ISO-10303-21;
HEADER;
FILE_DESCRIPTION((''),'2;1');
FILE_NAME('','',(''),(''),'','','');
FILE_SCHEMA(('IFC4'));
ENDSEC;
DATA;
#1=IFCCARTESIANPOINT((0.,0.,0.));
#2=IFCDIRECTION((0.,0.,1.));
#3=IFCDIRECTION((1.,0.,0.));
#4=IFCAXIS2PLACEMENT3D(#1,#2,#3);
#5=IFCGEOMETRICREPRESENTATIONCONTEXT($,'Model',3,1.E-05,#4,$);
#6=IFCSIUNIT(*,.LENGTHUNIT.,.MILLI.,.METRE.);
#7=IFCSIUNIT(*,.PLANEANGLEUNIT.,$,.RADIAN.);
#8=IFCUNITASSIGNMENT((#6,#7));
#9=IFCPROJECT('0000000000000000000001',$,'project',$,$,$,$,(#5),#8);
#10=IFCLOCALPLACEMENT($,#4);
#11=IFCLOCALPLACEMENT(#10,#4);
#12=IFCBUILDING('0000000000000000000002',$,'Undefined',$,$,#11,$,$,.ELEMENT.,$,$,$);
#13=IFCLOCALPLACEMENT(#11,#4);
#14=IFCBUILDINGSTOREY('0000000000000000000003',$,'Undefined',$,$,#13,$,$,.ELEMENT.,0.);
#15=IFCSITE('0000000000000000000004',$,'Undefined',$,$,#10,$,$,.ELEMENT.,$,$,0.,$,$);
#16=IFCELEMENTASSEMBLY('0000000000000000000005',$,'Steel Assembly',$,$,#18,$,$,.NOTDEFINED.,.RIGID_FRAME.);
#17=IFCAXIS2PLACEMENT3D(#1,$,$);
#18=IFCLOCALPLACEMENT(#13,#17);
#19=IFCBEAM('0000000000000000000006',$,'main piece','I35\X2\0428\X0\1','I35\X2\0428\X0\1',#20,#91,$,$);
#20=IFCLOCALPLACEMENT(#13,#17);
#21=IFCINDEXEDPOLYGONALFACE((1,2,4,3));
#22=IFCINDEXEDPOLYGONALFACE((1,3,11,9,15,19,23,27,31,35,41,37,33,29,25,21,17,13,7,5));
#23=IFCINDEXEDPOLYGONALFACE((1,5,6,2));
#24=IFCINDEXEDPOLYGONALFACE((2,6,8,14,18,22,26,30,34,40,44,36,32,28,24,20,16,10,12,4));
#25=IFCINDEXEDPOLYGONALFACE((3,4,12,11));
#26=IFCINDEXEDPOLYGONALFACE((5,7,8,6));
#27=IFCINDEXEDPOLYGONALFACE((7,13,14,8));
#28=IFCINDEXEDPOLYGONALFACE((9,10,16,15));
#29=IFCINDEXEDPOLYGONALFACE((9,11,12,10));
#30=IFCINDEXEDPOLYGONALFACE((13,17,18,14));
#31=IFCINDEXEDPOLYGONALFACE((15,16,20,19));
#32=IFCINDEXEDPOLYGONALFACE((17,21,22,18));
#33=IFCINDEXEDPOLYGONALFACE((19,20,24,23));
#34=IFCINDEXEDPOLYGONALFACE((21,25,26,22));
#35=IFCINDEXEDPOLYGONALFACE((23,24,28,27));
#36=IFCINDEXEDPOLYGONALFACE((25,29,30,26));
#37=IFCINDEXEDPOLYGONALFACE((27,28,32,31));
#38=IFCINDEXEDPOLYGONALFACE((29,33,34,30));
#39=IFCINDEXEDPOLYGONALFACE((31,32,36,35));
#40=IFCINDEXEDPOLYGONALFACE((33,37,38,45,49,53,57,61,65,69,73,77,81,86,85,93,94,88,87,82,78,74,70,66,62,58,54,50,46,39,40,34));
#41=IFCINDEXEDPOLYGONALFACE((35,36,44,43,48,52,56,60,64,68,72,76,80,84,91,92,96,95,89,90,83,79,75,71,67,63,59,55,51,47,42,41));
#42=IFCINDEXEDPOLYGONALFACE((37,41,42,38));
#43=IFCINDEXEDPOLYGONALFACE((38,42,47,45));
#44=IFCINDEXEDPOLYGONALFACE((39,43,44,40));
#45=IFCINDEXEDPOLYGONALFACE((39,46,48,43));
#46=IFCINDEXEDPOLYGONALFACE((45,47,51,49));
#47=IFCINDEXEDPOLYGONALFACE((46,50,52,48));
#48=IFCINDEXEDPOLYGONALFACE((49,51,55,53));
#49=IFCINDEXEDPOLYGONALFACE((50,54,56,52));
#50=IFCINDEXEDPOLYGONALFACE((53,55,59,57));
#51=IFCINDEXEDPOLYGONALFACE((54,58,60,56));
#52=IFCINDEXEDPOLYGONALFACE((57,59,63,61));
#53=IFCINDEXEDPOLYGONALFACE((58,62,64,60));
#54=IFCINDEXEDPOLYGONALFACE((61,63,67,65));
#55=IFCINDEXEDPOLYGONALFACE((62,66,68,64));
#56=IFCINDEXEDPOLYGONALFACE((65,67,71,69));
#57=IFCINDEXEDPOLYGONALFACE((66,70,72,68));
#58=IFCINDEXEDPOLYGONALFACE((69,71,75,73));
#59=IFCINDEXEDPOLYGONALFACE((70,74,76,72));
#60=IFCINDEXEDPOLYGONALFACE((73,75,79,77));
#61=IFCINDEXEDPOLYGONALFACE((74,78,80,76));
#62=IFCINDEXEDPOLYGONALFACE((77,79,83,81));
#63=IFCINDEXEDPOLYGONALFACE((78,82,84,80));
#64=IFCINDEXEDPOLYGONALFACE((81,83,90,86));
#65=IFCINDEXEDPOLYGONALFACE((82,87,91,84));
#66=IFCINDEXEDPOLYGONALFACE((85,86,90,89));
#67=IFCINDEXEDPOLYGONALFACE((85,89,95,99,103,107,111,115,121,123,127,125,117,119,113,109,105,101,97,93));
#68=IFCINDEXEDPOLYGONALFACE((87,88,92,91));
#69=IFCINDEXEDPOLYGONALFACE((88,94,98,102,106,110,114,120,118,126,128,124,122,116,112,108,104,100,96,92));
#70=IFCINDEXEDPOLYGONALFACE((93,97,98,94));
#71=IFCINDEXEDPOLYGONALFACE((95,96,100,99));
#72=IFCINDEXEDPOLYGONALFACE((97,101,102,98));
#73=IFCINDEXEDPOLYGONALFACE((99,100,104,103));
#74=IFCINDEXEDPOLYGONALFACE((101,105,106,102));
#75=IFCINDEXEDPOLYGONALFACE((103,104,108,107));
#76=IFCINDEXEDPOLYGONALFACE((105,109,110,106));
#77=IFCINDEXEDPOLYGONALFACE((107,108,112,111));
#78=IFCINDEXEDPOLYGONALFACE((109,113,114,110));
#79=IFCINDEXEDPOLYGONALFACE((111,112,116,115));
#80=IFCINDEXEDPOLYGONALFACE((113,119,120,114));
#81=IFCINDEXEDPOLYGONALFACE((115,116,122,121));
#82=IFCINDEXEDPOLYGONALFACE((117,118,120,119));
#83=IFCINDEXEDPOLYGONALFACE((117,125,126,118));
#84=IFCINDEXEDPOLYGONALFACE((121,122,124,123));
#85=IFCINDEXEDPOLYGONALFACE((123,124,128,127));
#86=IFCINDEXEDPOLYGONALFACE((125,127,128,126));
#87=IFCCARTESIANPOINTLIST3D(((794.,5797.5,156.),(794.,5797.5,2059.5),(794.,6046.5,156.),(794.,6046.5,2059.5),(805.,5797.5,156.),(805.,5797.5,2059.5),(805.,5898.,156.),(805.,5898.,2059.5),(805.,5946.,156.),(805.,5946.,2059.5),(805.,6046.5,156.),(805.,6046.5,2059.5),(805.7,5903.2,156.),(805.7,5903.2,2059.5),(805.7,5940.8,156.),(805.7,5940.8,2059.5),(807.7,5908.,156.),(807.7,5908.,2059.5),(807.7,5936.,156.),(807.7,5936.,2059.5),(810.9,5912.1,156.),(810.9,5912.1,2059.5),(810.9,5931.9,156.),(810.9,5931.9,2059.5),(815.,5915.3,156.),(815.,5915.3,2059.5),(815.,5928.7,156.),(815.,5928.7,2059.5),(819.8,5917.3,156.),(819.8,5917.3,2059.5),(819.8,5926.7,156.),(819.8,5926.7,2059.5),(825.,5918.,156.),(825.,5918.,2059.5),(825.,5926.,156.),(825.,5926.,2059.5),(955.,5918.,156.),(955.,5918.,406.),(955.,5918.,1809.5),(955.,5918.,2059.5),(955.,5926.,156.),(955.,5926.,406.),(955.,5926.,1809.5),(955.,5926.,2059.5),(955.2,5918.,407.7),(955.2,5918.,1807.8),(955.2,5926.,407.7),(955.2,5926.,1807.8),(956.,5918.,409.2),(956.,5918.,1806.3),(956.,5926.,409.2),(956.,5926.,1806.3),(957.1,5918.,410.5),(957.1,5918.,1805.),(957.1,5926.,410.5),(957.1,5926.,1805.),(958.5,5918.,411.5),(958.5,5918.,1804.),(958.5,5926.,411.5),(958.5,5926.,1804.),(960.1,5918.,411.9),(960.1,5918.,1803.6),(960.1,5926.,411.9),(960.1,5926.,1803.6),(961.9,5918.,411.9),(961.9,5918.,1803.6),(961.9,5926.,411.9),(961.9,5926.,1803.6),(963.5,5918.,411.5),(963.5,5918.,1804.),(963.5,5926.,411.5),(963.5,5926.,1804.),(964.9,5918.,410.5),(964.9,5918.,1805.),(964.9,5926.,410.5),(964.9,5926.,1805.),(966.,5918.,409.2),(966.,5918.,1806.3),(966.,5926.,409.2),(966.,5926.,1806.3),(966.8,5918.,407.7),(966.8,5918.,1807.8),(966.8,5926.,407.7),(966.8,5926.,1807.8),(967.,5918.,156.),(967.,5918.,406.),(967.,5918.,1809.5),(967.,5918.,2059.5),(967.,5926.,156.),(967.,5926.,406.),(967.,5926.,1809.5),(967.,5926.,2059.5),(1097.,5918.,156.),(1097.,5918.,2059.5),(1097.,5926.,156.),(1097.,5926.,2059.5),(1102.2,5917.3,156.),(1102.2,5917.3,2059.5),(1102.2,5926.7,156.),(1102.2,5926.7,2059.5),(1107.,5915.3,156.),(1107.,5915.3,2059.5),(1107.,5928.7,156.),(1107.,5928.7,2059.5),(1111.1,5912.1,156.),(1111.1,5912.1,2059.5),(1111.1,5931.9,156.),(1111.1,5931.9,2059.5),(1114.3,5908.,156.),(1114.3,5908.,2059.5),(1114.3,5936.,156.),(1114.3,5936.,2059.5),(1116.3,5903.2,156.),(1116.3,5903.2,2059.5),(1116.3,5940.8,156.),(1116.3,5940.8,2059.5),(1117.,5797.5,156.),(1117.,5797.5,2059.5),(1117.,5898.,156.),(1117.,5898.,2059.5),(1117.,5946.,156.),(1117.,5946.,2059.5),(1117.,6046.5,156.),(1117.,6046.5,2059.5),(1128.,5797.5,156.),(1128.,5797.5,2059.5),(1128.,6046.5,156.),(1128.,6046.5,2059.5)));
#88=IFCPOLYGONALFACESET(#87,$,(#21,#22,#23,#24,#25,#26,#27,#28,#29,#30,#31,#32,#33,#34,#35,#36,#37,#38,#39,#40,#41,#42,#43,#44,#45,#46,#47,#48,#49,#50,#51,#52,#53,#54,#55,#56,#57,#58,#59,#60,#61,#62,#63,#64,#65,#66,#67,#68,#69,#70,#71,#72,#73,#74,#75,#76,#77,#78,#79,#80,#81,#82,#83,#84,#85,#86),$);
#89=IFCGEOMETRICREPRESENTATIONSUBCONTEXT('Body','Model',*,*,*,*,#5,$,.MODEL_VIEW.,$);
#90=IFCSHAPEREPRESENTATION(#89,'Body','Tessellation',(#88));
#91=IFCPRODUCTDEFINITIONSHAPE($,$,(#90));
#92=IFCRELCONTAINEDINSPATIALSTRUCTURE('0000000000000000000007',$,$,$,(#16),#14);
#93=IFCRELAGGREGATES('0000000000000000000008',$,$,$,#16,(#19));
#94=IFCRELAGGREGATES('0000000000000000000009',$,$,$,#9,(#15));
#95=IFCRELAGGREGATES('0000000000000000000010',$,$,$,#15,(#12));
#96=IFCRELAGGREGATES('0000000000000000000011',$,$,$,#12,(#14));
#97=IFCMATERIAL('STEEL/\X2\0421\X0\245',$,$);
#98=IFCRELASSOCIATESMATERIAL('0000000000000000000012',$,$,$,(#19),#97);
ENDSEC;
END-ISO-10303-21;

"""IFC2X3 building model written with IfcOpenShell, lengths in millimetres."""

from ifc_helpers import new_model, si_unit, frame, frame_2d, origin_with_axes, origin_2d_with_axis, place, context, subcontext, project, spatial, polyline, circle_curve, parameter, trimmed, segment, composite_curve, i_section, outline, extrude, clip, halfspace, material, element, aggregate, save


model = new_model("IFC2X3")

# Units and contexts
model_context = context("Model", 3, precision=1e-05, world=origin_with_axes())
body_context = subcontext(model_context, "Body", "Model", "MODEL_VIEW")
ifc_project = project(units=[si_unit("LENGTHUNIT", "METRE", prefix="MILLI"), si_unit("PLANEANGLEUNIT", "RADIAN")], contexts=[model_context])

# Site, building, storey
site_placement = place(None, origin_with_axes())
site = spatial("IfcSite", under=ifc_project, at=site_placement, Name="Undefined", CompositionType="ELEMENT", RefElevation=0.0)
building_placement = place(site_placement, origin_with_axes())
building = spatial("IfcBuilding", under=site, at=building_placement, Name="Undefined", CompositionType="ELEMENT")
storey_placement = place(building_placement, origin_with_axes())
storey = spatial("IfcBuildingStorey", under=building, at=storey_placement, Name="Undefined", CompositionType="ELEMENT", Elevation=0.0)

# Element assembly, beam, openings
assembly_1_placement = place(storey_placement, origin_with_axes())
assembly_1 = element("IfcElementAssembly", 1, at=assembly_1_placement, inside=storey, Name="Steel Assembly", AssemblyPlace="NOTDEFINED", PredefinedType="RIGID_FRAME")
ifc_material_1 = material(Name="STEEL/С245")
beam_placement = place(assembly_1_placement, frame((961.0, 5922.0, 2059.5), z_axis=(1.0, 0.0, 0.0), x_axis=(0.0, 0.0, -1.0)))
beam = element("IfcBeam", 2, at=beam_placement, material=ifc_material_1, Name="main piece", Description="I35Ш1", ObjectType="I35Ш1", context=body_context, shape_type="Clipping", body=[
    clip(clip(extrude(i_section(OverallWidth=249.0, OverallDepth=334.0, WebThickness=8.0, FlangeThickness=11.0, FilletRadius=20.0, at=origin_2d_with_axis()), frame((1903.5, 0.0, 0.0), z_axis=(-1.0, 0.0, 0.0), x_axis=(0.0, -1.0, 0.0)), (0.0, 0.0, 1.0), 1903.5), halfspace(frame((1903.5, 0.6, 274.0), z_axis=(-1.0, 0.0, 0.0), x_axis=(0.0, -1.0, 0.0)), True)), halfspace(frame((0.0, -0.6, 274.0), z_axis=(1.0, 0.0, 0.0), x_axis=(0.0, 1.0, 0.0)), True)),
])
opening_1_placement = place(assembly_1_placement, frame((961.0, 5922.0, 2059.5), z_axis=(1.0, 0.0, 0.0), x_axis=(0.0, 0.0, -1.0)))
element("IfcOpeningElement", 3, at=opening_1_placement, cuts=beam, ObjectType="Recess", context=body_context, shape_type="SweptSolid", body=[
    extrude(outline(composite_curve([segment(polyline([(0.0, 0.0), (250.0, 0.0)]), True, "CONTINUOUS"), segment(trimmed(circle_curve(frame_2d((250.0, 6.0), x_axis=(-0.000939, -1.0)), 6.0), [parameter(0.0)], [parameter(3.14347)], True, "PARAMETER"), True, "CONTINUOUS"), segment(polyline([(250.0, 12.0), (0.0, 12.0), (0.0, 0.0)]), True, "DISCONTINUOUS")], self_intersect=False)), frame((1903.5, -102.5, -6.0), z_axis=(0.0, 1.0, 0.0), x_axis=(-1.0, 0.0, 0.0)), (0.0, 0.0, 1.0), 205.0),
])
opening_2_placement = place(assembly_1_placement, frame((961.0, 5922.0, 2059.5), z_axis=(1.0, 0.0, 0.0), x_axis=(0.0, 0.0, -1.0)))
element("IfcOpeningElement", 4, at=opening_2_placement, cuts=beam, ObjectType="Recess", context=body_context, shape_type="SweptSolid", body=[
    extrude(outline(composite_curve([segment(polyline([(0.0, 0.0), (250.0, 0.0)]), True, "CONTINUOUS"), segment(trimmed(circle_curve(frame_2d((250.0, 6.0), x_axis=(-0.000939, -1.0)), 6.0), [parameter(0.0)], [parameter(3.14347)], True, "PARAMETER"), True, "CONTINUOUS"), segment(polyline([(250.0, 12.0), (0.0, 12.0), (0.0, 0.0)]), True, "DISCONTINUOUS")], self_intersect=False)), frame((0.0, 102.5, -6.0), z_axis=(0.0, -1.0, 0.0), x_axis=(1.0, 0.0, 0.0)), (0.0, 0.0, 1.0), 205.0),
])

aggregate(assembly_1, [beam])

save(model, "model.ifc")
